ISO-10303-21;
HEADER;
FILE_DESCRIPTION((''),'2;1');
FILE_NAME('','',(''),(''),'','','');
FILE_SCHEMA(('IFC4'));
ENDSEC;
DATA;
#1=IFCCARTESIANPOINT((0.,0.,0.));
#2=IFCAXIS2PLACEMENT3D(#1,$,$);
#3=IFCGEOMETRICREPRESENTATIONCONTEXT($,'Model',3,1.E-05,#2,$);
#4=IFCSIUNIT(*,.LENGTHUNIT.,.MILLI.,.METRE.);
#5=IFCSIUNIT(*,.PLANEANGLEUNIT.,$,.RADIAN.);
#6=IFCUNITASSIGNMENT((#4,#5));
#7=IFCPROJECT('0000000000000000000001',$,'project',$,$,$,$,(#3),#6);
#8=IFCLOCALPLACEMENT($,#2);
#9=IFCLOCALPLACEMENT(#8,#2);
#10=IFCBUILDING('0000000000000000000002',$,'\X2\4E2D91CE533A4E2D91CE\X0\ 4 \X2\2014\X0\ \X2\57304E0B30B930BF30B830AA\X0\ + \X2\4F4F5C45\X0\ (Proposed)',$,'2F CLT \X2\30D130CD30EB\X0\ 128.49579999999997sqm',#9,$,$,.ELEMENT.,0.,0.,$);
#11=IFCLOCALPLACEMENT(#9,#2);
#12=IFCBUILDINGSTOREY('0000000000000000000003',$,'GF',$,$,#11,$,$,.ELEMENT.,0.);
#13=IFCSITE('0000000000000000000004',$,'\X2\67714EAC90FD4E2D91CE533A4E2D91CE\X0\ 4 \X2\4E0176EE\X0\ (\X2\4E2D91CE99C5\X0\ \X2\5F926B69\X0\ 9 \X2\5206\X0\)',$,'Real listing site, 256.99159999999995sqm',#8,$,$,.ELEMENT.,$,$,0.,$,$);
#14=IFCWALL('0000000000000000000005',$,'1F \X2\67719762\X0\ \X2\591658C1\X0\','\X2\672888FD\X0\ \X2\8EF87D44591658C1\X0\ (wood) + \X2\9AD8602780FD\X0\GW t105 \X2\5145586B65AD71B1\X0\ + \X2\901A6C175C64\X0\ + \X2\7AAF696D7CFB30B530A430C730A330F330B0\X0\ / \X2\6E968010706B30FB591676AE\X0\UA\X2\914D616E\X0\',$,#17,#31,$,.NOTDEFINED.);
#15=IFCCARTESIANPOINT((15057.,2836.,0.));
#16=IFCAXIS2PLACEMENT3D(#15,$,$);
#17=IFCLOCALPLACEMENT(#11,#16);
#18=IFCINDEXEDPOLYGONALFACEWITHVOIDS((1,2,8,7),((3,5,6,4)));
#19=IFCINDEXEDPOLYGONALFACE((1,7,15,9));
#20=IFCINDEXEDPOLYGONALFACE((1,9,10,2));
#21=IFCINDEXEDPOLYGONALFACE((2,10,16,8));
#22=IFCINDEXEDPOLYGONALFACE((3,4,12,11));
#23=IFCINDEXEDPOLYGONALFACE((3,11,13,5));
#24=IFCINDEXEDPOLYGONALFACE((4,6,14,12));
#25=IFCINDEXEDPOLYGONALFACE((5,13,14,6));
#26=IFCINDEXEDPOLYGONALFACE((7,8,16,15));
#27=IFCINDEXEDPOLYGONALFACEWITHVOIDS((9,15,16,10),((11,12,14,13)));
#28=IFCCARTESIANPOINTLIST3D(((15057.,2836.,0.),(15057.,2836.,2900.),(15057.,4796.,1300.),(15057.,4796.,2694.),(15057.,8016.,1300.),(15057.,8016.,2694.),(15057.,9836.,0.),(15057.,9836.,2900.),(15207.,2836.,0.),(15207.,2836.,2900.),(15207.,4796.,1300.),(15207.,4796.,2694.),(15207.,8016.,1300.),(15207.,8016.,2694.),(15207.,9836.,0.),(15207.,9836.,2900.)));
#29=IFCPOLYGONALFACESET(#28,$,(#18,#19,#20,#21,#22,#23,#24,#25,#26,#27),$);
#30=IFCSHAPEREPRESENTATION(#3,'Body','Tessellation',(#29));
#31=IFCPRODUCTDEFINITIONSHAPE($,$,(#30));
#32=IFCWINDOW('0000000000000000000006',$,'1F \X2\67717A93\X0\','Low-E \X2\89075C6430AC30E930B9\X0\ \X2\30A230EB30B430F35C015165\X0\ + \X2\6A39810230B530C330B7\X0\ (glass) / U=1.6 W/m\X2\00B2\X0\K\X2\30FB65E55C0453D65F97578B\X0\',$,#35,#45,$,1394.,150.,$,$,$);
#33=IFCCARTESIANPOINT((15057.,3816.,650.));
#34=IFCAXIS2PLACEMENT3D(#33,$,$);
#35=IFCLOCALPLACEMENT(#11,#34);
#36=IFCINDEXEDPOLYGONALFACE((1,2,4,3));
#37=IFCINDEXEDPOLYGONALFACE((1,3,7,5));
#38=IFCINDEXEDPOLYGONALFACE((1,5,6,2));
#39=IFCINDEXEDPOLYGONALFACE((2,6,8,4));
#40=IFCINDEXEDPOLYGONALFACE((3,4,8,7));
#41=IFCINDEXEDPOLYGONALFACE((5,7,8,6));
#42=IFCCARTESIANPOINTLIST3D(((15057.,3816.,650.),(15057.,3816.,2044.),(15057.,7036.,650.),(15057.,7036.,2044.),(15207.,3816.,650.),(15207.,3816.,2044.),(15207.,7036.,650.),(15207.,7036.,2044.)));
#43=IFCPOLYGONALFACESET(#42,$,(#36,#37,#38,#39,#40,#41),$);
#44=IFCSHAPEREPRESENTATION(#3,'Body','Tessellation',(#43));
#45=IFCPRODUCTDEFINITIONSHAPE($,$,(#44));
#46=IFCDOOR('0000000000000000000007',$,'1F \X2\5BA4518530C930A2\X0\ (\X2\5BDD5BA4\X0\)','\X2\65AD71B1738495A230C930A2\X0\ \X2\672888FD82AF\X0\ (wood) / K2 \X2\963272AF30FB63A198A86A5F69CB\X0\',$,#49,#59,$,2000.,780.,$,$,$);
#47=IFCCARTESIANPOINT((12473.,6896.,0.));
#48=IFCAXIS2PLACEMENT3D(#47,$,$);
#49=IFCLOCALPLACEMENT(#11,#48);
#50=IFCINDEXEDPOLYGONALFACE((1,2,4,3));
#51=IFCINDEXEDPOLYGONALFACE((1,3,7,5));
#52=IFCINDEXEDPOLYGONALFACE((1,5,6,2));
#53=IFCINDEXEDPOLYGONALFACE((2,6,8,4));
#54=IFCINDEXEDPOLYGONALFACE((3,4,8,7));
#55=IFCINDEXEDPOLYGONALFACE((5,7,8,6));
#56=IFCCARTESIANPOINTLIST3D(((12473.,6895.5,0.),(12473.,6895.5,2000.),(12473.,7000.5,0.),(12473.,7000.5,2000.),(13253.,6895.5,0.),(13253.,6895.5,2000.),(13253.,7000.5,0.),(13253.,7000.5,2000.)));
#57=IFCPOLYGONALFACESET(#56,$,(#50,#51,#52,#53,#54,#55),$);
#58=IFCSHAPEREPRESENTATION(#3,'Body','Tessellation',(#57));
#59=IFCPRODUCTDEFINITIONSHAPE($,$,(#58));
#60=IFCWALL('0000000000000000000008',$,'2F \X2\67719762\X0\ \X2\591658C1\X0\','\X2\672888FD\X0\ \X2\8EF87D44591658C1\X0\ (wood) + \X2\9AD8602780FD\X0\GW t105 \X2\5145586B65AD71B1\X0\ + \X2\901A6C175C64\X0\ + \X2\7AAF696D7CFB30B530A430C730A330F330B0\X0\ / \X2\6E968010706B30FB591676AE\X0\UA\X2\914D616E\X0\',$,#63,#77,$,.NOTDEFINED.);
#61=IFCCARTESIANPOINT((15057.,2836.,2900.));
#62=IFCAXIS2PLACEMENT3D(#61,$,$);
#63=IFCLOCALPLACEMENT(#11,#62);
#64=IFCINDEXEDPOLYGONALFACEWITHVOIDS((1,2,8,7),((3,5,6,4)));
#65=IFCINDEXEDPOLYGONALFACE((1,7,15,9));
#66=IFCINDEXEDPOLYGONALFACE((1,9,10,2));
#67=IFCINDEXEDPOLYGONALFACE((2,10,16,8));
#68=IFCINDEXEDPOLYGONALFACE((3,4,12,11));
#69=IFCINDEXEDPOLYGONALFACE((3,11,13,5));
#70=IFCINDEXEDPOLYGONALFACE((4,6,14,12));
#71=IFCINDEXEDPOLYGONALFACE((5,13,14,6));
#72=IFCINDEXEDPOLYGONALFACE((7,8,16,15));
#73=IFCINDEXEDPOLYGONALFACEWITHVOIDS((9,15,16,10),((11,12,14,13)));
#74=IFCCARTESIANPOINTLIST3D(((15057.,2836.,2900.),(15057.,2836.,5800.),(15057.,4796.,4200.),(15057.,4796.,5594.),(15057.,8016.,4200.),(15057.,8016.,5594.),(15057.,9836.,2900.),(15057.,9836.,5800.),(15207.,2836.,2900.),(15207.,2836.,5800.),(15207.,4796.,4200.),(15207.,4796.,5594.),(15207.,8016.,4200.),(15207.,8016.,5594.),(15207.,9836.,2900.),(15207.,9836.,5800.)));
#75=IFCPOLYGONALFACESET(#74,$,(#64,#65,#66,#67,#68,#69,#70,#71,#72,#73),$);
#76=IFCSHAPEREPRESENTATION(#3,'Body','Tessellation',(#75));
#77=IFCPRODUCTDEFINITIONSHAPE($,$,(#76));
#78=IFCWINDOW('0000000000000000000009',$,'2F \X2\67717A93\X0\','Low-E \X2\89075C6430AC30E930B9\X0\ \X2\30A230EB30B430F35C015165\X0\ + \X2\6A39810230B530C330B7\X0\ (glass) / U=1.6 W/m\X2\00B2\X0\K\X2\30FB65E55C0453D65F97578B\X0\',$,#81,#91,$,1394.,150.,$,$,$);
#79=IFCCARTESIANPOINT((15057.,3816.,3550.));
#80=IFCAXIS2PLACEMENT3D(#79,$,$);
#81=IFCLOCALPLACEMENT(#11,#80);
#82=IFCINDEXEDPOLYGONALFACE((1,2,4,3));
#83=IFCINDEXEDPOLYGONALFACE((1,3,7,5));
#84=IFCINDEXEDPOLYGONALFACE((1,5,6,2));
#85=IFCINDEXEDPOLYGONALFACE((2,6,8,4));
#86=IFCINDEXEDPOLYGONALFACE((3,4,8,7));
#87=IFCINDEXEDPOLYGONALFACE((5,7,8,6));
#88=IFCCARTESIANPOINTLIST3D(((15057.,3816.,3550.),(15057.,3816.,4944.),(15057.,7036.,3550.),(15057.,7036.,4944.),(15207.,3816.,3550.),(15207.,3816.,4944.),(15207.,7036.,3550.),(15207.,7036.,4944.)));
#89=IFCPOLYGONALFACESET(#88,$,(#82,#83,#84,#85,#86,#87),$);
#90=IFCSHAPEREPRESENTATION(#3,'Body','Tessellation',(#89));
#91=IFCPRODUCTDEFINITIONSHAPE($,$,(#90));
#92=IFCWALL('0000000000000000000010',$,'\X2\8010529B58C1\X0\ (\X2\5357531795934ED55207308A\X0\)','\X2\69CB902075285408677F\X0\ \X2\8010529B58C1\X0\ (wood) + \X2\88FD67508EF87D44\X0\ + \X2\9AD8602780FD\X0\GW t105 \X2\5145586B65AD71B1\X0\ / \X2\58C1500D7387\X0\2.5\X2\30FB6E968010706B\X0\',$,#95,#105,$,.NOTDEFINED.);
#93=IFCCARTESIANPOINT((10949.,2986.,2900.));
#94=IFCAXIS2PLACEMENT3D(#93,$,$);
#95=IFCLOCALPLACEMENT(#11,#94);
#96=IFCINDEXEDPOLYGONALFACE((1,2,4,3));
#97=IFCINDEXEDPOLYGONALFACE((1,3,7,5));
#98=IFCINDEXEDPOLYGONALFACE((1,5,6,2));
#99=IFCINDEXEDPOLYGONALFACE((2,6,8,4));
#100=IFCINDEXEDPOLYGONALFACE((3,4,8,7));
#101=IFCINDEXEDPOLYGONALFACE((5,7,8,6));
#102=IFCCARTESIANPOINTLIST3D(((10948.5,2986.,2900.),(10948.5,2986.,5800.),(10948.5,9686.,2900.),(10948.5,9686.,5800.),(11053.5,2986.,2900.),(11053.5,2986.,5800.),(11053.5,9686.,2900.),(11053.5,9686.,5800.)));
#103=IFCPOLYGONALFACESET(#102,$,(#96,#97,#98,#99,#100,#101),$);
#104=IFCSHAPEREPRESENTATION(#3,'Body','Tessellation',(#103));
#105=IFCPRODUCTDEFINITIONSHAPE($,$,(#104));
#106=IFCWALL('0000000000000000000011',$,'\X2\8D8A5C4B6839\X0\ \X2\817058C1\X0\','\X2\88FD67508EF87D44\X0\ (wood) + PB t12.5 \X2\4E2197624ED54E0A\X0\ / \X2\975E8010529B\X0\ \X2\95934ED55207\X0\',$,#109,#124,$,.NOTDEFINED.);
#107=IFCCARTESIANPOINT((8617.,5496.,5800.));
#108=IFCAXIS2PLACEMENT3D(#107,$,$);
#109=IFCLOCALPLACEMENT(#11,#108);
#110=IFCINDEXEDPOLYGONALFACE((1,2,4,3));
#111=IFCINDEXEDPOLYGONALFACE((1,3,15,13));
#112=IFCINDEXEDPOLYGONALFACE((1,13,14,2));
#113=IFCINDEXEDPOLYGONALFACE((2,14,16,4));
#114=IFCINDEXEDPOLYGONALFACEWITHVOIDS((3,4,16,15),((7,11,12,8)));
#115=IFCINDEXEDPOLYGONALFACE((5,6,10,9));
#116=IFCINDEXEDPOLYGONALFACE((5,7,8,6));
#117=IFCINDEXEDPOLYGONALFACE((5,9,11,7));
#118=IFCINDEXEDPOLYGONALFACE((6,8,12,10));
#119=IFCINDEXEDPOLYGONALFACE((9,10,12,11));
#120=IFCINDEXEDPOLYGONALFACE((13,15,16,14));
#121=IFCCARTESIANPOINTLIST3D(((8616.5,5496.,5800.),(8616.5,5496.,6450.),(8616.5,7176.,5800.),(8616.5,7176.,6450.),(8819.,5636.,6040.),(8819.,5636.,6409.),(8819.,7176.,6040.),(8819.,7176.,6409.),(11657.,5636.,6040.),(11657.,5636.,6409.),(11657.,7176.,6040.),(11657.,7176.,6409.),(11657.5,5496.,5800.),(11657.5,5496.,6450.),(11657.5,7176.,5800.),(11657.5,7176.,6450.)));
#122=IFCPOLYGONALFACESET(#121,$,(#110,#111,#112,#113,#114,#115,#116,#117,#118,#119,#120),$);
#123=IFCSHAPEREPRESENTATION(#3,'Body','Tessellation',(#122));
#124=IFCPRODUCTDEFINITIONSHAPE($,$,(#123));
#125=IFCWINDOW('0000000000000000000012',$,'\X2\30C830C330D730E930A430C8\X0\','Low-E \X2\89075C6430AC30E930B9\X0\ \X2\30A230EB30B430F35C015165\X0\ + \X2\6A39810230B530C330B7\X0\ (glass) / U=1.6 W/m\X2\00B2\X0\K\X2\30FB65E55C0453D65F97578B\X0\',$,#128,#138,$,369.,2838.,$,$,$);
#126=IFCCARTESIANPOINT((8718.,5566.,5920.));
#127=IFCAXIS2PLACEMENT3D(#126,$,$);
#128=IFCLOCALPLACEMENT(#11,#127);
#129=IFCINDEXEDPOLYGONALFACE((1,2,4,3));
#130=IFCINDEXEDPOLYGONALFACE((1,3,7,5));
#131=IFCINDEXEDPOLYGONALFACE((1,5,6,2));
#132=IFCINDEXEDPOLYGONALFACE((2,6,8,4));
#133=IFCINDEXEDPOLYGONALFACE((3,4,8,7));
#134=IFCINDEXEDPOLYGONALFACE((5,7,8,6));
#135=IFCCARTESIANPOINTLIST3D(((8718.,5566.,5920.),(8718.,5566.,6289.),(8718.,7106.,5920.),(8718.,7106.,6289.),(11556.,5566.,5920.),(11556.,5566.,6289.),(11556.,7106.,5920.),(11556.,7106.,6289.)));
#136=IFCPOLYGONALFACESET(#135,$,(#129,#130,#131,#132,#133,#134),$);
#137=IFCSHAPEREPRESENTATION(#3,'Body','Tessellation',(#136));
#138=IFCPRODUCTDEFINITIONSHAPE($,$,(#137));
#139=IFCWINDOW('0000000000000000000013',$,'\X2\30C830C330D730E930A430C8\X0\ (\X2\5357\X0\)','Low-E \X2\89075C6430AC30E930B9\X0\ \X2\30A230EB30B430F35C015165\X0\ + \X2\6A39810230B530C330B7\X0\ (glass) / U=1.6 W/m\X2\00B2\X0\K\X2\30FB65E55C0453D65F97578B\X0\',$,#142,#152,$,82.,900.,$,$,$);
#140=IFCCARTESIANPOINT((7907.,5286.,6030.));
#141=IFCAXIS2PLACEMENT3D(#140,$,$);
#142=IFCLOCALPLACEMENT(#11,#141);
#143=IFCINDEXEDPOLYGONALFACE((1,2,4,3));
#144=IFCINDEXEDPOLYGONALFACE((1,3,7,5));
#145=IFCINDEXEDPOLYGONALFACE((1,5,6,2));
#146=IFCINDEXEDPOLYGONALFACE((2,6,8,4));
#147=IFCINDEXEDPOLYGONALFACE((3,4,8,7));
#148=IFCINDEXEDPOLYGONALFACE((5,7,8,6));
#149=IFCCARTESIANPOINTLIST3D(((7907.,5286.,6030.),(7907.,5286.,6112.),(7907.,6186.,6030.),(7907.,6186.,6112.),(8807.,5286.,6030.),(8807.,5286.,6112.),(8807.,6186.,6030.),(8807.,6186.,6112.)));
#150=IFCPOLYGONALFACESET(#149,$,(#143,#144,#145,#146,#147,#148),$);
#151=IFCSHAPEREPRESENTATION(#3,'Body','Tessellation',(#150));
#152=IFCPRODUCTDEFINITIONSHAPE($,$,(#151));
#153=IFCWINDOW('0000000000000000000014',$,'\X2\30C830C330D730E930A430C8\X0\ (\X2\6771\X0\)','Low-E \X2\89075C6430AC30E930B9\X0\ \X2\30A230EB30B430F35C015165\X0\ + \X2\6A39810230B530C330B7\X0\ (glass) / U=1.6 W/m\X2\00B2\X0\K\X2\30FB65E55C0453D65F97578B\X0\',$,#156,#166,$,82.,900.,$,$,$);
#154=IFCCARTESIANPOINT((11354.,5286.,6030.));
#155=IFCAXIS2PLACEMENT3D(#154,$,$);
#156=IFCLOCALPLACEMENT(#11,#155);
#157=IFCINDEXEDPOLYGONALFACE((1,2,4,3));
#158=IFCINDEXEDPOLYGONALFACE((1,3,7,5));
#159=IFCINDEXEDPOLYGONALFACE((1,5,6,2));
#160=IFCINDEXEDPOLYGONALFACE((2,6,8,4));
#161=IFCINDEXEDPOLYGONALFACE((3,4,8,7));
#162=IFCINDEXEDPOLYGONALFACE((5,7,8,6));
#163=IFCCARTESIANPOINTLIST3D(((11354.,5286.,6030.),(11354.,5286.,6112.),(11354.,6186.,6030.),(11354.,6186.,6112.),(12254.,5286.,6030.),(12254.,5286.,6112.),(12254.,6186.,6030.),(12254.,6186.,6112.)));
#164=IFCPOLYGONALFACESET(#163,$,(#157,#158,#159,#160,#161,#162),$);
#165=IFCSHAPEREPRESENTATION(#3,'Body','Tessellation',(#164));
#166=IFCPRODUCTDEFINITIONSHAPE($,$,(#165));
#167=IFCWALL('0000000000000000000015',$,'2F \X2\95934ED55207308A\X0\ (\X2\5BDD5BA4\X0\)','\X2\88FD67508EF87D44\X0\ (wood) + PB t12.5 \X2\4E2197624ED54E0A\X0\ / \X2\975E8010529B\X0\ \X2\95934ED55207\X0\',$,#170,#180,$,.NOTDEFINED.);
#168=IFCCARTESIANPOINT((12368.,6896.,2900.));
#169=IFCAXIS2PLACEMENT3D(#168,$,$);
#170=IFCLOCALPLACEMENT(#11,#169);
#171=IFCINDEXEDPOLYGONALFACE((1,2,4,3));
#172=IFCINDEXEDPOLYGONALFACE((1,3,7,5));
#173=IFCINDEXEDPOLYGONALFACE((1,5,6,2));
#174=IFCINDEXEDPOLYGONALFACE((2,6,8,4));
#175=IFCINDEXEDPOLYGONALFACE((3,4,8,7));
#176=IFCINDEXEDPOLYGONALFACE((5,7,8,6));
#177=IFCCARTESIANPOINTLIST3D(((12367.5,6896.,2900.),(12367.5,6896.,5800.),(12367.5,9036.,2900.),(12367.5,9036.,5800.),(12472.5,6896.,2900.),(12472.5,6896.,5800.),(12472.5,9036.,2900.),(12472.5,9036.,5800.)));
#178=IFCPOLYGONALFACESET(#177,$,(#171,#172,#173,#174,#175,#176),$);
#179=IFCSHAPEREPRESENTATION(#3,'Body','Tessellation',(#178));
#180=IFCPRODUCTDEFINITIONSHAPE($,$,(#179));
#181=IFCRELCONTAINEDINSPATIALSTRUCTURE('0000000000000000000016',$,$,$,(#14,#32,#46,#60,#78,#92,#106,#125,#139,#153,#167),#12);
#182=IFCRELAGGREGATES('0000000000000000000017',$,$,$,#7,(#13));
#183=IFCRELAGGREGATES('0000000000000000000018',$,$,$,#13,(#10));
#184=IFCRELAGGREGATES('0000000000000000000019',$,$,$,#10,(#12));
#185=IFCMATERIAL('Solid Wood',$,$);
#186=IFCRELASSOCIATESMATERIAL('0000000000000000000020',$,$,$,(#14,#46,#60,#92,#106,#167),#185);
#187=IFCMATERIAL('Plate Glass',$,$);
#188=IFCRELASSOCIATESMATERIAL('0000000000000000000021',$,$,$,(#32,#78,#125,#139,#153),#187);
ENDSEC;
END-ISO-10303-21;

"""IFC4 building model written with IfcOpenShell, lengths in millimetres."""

from ifc_helpers import new_model, si_unit, frame, frame_2d, origin, place, context, project, spatial, rectangle, extrude, material, element, fill, save


model = new_model("IFC4")

# Units and contexts
model_context = context("Model", 3, precision=1e-05, world=origin())
ifc_project = project(units=[si_unit("LENGTHUNIT", "METRE", prefix="MILLI"), si_unit("PLANEANGLEUNIT", "RADIAN")], contexts=[model_context])

# Site, building, storey
site_placement = place(None, origin())
site = spatial("IfcSite", under=ifc_project, at=site_placement, Name="東京都中野区中野 4 丁目 (中野駅 徒歩 9 分)", ObjectType="Real listing site, 256.99159999999995sqm", CompositionType="ELEMENT", RefElevation=0.0)
building_placement = place(site_placement, origin())
building = spatial("IfcBuilding", under=site, at=building_placement, Name="中野区中野 4 — 地下スタジオ + 住居 (Proposed)", ObjectType="2F CLT パネル 128.49579999999997sqm", CompositionType="ELEMENT", ElevationOfRefHeight=0.0, ElevationOfTerrain=0.0)
storey_placement = place(building_placement, origin())
storey = spatial("IfcBuildingStorey", under=building, at=storey_placement, Name="GF", CompositionType="ELEMENT", Elevation=0.0)

# Wall, opening, window
ifc_material_1 = material(Name="Solid Wood")
wall_1_placement = place(storey_placement, frame((15057.0, 2836.0, 0.0)))
wall_1 = element("IfcWall", 1, at=wall_1_placement, inside=storey, material=ifc_material_1, Name="1F 東面 外壁", Description="木製 軸組外壁 (wood) + 高性能GW t105 充填断熱 + 通気層 + 窯業系サイディング / 準耐火・外皮UA配慮", PredefinedType="NOTDEFINED", context=model_context, shape_type="SweptSolid", body=[
    extrude(rectangle(XDim=150.0, YDim=7000.0, at=frame_2d((75.0, 3500.0))), frame((15057.0, 2836.0, 0.0)), (0.0, 0.0, 1.0), 2900.0),
])
opening_1_placement = place(storey_placement, frame((15057.0, 3816.0, 650.0)))
opening_1 = element("IfcOpeningElement", 2, at=opening_1_placement, cuts=wall_1, PredefinedType="NOTDEFINED", context=model_context, shape_type="SweptSolid", body=[
    extrude(rectangle(XDim=150.0, YDim=3220.0, at=frame_2d((75.0, 1610.0))), frame((15057.0, 3816.0, 650.0)), (0.0, 0.0, 1.0), 1394.0),
])
ifc_material_2 = material(Name="Plate Glass")
window_1_placement = place(storey_placement, frame((15057.0, 3816.0, 650.0)))
window_1 = element("IfcWindow", 3, at=window_1_placement, inside=storey, material=ifc_material_2, Name="1F 東窓", Description="Low-E 複層ガラス アルゴン封入 + 樹脂サッシ (glass) / U=1.6 W/m²K・日射取得型", OverallHeight=1394.0, OverallWidth=150.0, context=model_context, shape_type="SweptSolid", body=[
    extrude(rectangle(XDim=150.0, YDim=3220.0, at=frame_2d((75.0, 1610.0))), frame((15057.0, 3816.0, 650.0)), (0.0, 0.0, 1.0), 1394.0),
])
fill(opening_1, window_1)

# Door
door_1_placement = place(storey_placement, frame((12473.0, 6896.0, 0.0)))
element("IfcDoor", 4, at=door_1_placement, inside=storey, material=ifc_material_1, Name="1F 室内ドア (寝室)", Description="断熱玄関ドア 木製芯 (wood) / K2 防犯・採風機構", OverallHeight=2000.0, OverallWidth=780.0, context=model_context, shape_type="SweptSolid", body=[
    extrude(rectangle(XDim=780.0, YDim=105.0, at=frame_2d((390.0, 52.0))), frame((12473.0, 6896.0, 0.0)), (0.0, 0.0, 1.0), 2000.0),
])

# Wall, opening, window
wall_2_placement = place(storey_placement, frame((15057.0, 2836.0, 2900.0)))
wall_2 = element("IfcWall", 5, at=wall_2_placement, inside=storey, material=ifc_material_1, Name="2F 東面 外壁", Description="木製 軸組外壁 (wood) + 高性能GW t105 充填断熱 + 通気層 + 窯業系サイディング / 準耐火・外皮UA配慮", PredefinedType="NOTDEFINED", context=model_context, shape_type="SweptSolid", body=[
    extrude(rectangle(XDim=150.0, YDim=7000.0, at=frame_2d((75.0, 3500.0))), frame((15057.0, 2836.0, 2900.0)), (0.0, 0.0, 1.0), 2900.0),
])
opening_2_placement = place(storey_placement, frame((15057.0, 3816.0, 3550.0)))
opening_2 = element("IfcOpeningElement", 6, at=opening_2_placement, cuts=wall_2, PredefinedType="NOTDEFINED", context=model_context, shape_type="SweptSolid", body=[
    extrude(rectangle(XDim=150.0, YDim=3220.0, at=frame_2d((75.0, 1610.0))), frame((15057.0, 3816.0, 3550.0)), (0.0, 0.0, 1.0), 1394.0),
])
window_2_placement = place(storey_placement, frame((15057.0, 3816.0, 3550.0)))
window_2 = element("IfcWindow", 7, at=window_2_placement, inside=storey, material=ifc_material_2, Name="2F 東窓", Description="Low-E 複層ガラス アルゴン封入 + 樹脂サッシ (glass) / U=1.6 W/m²K・日射取得型", OverallHeight=1394.0, OverallWidth=150.0, context=model_context, shape_type="SweptSolid", body=[
    extrude(rectangle(XDim=150.0, YDim=3220.0, at=frame_2d((75.0, 1610.0))), frame((15057.0, 3816.0, 3550.0)), (0.0, 0.0, 1.0), 1394.0),
])
fill(opening_2, window_2)

# Wall
wall_3_placement = place(storey_placement, frame((10949.0, 2986.0, 2900.0)))
element("IfcWall", 8, at=wall_3_placement, inside=storey, material=ifc_material_1, Name="耐力壁 (南北間仕切り)", Description="構造用合板 耐力壁 (wood) + 製材軸組 + 高性能GW t105 充填断熱 / 壁倍率2.5・準耐火", PredefinedType="NOTDEFINED", context=model_context, shape_type="SweptSolid", body=[
    extrude(rectangle(XDim=105.0, YDim=6700.0, at=frame_2d((52.0, 3350.0))), frame((10949.0, 2986.0, 2900.0)), (0.0, 0.0, 1.0), 2900.0),
])

# Wall, openings, windows
wall_4_placement = place(storey_placement, frame((8617.0, 5496.0, 5800.0)))
wall_4 = element("IfcWall", 9, at=wall_4_placement, inside=storey, material=ifc_material_1, Name="越屋根 腰壁", Description="製材軸組 (wood) + PB t12.5 両面仕上 / 非耐力 間仕切", PredefinedType="NOTDEFINED", context=model_context, shape_type="SweptSolid", body=[
    extrude(rectangle(XDim=3041.0, YDim=1680.0, at=frame_2d((1520.0, 840.0))), frame((8617.0, 5496.0, 5800.0)), (0.0, 0.0, 1.0), 650.0),
])
opening_3_placement = place(storey_placement, frame((8718.0, 5566.0, 5920.0)))
opening_3 = element("IfcOpeningElement", 10, at=opening_3_placement, cuts=wall_4, PredefinedType="NOTDEFINED", context=model_context, shape_type="SweptSolid", body=[
    extrude(rectangle(XDim=2838.0, YDim=1540.0, at=frame_2d((1419.0, 770.0))), frame((8718.0, 5566.0, 5920.0)), (0.0, 0.0, 1.0), 369.0),
])
opening_4_placement = place(storey_placement, frame((7907.0, 5286.0, 6030.0)))
opening_4 = element("IfcOpeningElement", 11, at=opening_4_placement, cuts=wall_4, PredefinedType="NOTDEFINED", context=model_context, shape_type="SweptSolid", body=[
    extrude(rectangle(XDim=900.0, YDim=900.0, at=frame_2d((450.0, 450.0))), frame((7907.0, 5286.0, 6030.0)), (0.0, 0.0, 1.0), 82.0),
])
opening_5_placement = place(storey_placement, frame((11354.0, 5286.0, 6030.0)))
opening_5 = element("IfcOpeningElement", 12, at=opening_5_placement, cuts=wall_4, PredefinedType="NOTDEFINED", context=model_context, shape_type="SweptSolid", body=[
    extrude(rectangle(XDim=900.0, YDim=900.0, at=frame_2d((450.0, 450.0))), frame((11354.0, 5286.0, 6030.0)), (0.0, 0.0, 1.0), 82.0),
])
window_3_placement = place(storey_placement, frame((8718.0, 5566.0, 5920.0)))
window_3 = element("IfcWindow", 13, at=window_3_placement, inside=storey, material=ifc_material_2, Name="トップライト", Description="Low-E 複層ガラス アルゴン封入 + 樹脂サッシ (glass) / U=1.6 W/m²K・日射取得型", OverallHeight=369.0, OverallWidth=2838.0, context=model_context, shape_type="SweptSolid", body=[
    extrude(rectangle(XDim=2838.0, YDim=1540.0, at=frame_2d((1419.0, 770.0))), frame((8718.0, 5566.0, 5920.0)), (0.0, 0.0, 1.0), 369.0),
])
fill(opening_3, window_3)
window_4_placement = place(storey_placement, frame((7907.0, 5286.0, 6030.0)))
window_4 = element("IfcWindow", 14, at=window_4_placement, inside=storey, material=ifc_material_2, Name="トップライト (南)", Description="Low-E 複層ガラス アルゴン封入 + 樹脂サッシ (glass) / U=1.6 W/m²K・日射取得型", OverallHeight=82.0, OverallWidth=900.0, context=model_context, shape_type="SweptSolid", body=[
    extrude(rectangle(XDim=900.0, YDim=900.0, at=frame_2d((450.0, 450.0))), frame((7907.0, 5286.0, 6030.0)), (0.0, 0.0, 1.0), 82.0),
])
fill(opening_4, window_4)
window_5_placement = place(storey_placement, frame((11354.0, 5286.0, 6030.0)))
window_5 = element("IfcWindow", 15, at=window_5_placement, inside=storey, material=ifc_material_2, Name="トップライト (東)", Description="Low-E 複層ガラス アルゴン封入 + 樹脂サッシ (glass) / U=1.6 W/m²K・日射取得型", OverallHeight=82.0, OverallWidth=900.0, context=model_context, shape_type="SweptSolid", body=[
    extrude(rectangle(XDim=900.0, YDim=900.0, at=frame_2d((450.0, 450.0))), frame((11354.0, 5286.0, 6030.0)), (0.0, 0.0, 1.0), 82.0),
])
fill(opening_5, window_5)

# Wall
wall_5_placement = place(storey_placement, frame((12368.0, 6896.0, 2900.0)))
element("IfcWall", 16, at=wall_5_placement, inside=storey, material=ifc_material_1, Name="2F 間仕切り (寝室)", Description="製材軸組 (wood) + PB t12.5 両面仕上 / 非耐力 間仕切", PredefinedType="NOTDEFINED", context=model_context, shape_type="SweptSolid", body=[
    extrude(rectangle(XDim=105.0, YDim=2140.0, at=frame_2d((52.0, 1070.0))), frame((12368.0, 6896.0, 2900.0)), (0.0, 0.0, 1.0), 2900.0),
])

save(model, "model.ifc")
